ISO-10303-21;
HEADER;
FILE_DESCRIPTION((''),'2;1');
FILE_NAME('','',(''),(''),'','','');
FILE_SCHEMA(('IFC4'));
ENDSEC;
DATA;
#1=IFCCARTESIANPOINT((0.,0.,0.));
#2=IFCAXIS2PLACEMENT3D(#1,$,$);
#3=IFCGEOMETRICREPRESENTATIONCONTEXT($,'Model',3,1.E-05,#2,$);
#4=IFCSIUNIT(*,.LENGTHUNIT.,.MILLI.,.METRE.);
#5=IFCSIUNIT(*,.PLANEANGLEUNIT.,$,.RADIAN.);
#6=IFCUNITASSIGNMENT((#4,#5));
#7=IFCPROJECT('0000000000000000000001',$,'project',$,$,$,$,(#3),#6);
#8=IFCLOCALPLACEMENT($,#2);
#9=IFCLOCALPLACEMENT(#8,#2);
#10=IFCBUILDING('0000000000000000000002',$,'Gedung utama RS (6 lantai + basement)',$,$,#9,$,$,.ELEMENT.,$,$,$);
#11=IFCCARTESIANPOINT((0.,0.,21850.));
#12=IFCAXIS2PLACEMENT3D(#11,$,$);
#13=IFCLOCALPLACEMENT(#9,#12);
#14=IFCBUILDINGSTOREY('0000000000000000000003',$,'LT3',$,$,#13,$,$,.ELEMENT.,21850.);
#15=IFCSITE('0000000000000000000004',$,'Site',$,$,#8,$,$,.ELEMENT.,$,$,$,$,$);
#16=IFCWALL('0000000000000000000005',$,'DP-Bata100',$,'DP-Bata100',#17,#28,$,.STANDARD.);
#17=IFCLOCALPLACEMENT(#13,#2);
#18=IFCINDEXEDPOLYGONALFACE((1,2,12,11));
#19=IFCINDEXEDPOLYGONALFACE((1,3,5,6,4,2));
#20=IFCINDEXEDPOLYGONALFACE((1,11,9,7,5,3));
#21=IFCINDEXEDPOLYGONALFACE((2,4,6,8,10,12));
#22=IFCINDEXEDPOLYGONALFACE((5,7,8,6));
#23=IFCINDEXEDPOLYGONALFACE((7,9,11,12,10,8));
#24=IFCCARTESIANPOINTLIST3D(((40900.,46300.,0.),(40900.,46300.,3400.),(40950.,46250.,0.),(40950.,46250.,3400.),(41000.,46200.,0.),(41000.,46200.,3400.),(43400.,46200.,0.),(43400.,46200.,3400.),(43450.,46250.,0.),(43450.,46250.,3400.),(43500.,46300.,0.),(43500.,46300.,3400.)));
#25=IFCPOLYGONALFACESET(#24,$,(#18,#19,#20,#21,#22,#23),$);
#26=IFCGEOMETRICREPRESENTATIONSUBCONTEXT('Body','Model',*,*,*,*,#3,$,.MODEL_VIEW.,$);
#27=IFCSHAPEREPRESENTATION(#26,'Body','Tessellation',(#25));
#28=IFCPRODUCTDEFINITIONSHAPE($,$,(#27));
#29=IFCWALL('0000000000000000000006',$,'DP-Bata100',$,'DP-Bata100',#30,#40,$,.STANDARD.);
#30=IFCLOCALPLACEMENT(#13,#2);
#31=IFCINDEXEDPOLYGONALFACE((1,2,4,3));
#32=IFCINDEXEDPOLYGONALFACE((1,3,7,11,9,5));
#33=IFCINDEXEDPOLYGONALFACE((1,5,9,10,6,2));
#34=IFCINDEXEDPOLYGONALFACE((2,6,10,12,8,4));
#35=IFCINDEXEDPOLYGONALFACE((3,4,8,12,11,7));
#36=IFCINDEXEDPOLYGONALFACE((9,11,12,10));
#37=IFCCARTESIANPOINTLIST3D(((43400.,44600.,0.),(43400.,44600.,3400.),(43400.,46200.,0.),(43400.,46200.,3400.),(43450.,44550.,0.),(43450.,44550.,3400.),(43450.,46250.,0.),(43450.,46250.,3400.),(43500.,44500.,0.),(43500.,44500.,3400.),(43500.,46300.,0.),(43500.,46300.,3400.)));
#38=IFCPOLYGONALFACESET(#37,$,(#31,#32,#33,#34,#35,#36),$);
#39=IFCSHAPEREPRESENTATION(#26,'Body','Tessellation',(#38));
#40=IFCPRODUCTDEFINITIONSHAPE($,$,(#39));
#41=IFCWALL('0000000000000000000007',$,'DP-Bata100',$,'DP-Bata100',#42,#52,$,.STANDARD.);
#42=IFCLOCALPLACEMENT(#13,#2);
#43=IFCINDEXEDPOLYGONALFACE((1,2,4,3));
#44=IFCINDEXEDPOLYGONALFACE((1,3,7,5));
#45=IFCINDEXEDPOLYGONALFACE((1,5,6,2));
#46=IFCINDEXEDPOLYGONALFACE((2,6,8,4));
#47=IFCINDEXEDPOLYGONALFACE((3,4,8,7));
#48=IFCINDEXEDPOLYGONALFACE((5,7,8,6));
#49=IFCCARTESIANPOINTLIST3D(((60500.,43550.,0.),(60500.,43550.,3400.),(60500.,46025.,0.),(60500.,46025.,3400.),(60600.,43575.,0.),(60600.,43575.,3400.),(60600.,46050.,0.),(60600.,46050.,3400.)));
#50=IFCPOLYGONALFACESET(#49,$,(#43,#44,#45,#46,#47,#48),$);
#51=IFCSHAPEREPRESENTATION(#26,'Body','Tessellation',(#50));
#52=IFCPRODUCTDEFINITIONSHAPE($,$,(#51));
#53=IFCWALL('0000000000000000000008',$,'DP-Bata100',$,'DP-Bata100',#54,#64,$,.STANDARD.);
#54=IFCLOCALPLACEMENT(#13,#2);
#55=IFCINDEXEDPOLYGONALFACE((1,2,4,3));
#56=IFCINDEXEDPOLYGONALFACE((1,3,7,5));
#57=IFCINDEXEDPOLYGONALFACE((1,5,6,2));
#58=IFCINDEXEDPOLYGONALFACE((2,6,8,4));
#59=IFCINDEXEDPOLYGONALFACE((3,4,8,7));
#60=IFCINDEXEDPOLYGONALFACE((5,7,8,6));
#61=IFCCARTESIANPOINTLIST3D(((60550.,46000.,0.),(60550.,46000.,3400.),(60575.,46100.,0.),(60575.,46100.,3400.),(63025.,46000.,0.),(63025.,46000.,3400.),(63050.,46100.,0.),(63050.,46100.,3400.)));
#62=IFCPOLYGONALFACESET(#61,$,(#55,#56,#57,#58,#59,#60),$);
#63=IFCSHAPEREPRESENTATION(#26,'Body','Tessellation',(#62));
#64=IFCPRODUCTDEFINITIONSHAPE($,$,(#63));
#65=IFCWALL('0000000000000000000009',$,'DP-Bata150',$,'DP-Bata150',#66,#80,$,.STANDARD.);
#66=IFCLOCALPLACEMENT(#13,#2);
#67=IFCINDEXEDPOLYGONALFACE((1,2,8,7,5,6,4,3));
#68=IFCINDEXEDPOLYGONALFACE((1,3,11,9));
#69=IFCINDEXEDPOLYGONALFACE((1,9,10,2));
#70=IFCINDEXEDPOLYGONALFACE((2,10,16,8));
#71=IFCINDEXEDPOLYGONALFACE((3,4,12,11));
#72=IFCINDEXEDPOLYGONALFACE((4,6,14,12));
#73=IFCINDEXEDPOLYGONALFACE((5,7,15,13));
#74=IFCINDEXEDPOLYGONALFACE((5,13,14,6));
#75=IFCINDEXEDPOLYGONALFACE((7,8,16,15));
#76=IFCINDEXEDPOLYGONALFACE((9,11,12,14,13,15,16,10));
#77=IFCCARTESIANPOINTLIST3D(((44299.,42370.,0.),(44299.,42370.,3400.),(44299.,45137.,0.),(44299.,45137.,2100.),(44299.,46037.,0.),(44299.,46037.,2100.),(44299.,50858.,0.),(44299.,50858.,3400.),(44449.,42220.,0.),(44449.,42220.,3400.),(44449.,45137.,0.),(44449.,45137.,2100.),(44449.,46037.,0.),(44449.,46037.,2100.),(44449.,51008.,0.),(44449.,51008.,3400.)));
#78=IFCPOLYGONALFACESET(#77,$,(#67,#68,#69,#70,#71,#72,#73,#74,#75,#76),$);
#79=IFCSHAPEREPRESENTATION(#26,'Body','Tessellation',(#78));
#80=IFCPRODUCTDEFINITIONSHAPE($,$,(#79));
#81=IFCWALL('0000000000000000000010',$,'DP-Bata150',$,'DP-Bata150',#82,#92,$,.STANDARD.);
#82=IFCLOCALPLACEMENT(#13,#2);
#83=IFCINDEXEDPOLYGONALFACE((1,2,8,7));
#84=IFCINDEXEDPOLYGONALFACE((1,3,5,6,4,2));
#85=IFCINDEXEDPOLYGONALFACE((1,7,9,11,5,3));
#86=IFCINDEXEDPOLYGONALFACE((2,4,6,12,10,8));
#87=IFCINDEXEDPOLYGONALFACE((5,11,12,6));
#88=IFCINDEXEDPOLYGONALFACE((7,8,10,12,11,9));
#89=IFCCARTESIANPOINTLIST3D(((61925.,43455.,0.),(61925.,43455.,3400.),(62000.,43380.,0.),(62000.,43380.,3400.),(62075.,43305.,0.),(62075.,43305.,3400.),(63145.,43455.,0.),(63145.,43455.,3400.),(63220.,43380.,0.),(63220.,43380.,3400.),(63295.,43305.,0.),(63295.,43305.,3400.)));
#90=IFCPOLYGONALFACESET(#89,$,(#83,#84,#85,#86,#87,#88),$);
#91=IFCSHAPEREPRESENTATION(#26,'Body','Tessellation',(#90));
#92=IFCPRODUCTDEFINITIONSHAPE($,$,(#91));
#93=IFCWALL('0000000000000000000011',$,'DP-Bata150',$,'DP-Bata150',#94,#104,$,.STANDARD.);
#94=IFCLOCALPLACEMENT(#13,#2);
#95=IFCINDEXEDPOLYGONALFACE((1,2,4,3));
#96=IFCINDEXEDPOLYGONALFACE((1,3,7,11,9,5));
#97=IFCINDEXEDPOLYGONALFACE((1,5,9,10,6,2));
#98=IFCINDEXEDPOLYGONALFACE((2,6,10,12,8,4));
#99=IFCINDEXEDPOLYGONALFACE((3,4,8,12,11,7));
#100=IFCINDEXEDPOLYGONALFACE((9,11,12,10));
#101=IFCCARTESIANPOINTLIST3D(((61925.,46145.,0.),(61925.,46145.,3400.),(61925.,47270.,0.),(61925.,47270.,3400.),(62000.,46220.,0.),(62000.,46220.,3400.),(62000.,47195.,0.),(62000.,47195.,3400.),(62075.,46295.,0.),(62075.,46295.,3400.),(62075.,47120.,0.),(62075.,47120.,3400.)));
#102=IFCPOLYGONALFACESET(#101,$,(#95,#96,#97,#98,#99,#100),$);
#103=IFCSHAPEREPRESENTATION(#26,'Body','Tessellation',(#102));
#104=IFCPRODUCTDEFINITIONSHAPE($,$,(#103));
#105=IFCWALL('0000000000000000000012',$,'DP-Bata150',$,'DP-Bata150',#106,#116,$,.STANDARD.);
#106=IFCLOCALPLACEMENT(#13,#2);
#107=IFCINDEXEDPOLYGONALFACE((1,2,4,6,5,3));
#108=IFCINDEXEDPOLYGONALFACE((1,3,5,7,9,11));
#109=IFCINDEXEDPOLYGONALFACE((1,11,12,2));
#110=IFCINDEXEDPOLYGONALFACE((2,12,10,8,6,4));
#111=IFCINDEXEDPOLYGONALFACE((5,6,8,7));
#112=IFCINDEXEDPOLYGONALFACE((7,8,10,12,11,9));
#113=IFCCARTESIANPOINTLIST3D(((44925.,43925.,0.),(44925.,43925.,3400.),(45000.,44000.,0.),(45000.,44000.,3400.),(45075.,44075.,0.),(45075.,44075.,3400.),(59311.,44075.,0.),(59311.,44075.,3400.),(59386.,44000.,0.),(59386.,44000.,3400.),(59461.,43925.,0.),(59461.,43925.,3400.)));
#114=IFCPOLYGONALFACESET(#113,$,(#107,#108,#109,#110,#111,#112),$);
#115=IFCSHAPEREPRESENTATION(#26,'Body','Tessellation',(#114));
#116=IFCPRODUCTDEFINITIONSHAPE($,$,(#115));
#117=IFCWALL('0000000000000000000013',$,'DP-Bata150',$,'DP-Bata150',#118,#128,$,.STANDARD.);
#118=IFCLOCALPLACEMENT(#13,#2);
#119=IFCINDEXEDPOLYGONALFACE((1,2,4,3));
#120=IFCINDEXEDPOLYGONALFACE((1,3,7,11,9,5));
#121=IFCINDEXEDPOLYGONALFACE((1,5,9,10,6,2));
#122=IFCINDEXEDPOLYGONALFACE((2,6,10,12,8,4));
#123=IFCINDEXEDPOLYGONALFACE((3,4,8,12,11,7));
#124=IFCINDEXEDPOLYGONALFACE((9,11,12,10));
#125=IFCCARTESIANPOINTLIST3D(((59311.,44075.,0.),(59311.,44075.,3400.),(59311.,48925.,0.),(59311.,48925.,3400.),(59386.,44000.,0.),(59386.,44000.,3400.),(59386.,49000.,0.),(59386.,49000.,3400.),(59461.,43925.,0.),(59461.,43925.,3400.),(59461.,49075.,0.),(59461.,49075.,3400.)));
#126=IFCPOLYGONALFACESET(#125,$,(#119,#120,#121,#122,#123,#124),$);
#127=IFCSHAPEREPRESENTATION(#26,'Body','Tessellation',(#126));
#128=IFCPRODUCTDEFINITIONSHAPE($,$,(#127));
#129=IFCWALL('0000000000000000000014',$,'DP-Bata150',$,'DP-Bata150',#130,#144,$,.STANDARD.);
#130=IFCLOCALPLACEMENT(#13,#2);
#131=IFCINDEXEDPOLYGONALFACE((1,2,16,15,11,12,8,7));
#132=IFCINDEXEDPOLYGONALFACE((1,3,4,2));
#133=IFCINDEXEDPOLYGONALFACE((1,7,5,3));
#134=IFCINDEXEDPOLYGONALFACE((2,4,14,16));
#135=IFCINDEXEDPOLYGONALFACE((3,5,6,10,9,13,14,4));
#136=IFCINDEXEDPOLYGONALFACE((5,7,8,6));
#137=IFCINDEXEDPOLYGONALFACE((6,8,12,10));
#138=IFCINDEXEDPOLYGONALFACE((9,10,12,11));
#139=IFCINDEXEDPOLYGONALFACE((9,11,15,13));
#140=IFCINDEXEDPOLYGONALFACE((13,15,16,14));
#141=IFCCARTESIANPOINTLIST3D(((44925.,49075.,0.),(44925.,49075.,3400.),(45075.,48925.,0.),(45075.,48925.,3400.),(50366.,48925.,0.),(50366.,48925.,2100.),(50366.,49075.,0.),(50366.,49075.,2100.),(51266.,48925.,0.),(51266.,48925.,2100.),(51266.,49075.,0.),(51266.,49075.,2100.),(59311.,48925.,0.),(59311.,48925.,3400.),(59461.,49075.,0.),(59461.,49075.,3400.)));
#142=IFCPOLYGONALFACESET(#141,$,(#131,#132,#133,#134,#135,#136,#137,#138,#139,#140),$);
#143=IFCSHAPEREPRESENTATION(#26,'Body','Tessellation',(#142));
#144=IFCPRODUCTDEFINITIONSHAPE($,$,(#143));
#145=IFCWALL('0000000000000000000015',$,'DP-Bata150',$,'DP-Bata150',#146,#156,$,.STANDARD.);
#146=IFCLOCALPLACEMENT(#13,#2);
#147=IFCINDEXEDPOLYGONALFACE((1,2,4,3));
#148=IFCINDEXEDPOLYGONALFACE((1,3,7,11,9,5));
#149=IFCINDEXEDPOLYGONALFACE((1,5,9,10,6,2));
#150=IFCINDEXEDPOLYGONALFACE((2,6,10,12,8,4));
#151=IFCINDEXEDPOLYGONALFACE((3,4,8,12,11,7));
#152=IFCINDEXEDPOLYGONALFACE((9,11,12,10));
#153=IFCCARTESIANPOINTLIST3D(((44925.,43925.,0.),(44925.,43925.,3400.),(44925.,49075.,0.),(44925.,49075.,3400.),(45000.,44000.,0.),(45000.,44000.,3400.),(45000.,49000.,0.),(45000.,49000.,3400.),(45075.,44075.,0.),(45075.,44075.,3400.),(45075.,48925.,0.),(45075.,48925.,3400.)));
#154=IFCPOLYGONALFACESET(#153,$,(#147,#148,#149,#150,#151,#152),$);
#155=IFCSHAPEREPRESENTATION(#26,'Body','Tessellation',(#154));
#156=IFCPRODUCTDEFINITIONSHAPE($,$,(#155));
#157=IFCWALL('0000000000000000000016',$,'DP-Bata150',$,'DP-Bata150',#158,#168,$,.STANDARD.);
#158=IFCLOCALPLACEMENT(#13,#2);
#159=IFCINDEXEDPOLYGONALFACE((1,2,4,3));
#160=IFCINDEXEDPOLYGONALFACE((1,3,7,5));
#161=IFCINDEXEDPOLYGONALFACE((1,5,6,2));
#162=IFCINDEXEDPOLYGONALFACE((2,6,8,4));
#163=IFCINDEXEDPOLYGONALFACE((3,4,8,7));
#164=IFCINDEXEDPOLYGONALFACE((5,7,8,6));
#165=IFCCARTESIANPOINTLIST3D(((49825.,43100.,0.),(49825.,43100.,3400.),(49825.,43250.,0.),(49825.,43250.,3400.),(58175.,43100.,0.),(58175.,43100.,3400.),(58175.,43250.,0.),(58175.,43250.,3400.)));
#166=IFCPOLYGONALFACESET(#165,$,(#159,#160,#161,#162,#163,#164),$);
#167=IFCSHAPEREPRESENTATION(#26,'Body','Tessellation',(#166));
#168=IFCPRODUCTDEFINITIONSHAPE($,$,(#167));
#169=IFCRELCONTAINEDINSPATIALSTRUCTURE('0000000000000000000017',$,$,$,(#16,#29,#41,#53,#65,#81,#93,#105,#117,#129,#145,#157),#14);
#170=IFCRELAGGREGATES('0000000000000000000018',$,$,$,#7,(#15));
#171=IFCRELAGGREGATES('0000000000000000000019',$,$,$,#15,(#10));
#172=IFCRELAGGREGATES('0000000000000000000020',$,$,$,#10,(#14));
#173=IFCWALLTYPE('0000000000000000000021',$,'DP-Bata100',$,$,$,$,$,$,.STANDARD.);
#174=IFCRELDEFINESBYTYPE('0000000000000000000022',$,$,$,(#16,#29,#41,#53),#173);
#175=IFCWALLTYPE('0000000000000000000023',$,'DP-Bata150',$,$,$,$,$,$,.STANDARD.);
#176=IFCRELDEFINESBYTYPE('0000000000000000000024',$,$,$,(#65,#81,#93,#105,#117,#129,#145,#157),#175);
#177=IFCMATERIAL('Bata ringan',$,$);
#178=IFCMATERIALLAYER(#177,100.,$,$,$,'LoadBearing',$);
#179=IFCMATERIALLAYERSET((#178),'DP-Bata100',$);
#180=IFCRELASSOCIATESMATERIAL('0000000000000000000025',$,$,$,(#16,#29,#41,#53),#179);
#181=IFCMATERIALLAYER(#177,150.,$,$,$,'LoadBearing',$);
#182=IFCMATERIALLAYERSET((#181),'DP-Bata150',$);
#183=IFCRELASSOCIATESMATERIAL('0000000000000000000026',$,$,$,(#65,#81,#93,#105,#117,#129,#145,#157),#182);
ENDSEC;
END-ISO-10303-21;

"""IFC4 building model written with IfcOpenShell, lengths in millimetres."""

from ifc_helpers import new_model, si_unit, frame, frame_2d, origin, place, context, subcontext, project, spatial, polyline, rectangle, outline, extrude, material, layer, layer_set, layer_usage, type_object, element, save


model = new_model("IFC4")

# Units and contexts
model_context = context("Model", 3, precision=1e-05, world=origin())
body_context = subcontext(model_context, "Body", "Model", "MODEL_VIEW")
ifc_project = project(units=[si_unit("LENGTHUNIT", "METRE", prefix="MILLI"), si_unit("PLANEANGLEUNIT", "RADIAN")], contexts=[model_context])

# Site, building, storey
site_placement = place(None, origin())
site = spatial("IfcSite", under=ifc_project, at=site_placement, Name="Site", CompositionType="ELEMENT")
building_placement = place(site_placement, origin())
building = spatial("IfcBuilding", under=site, at=building_placement, Name="Gedung utama RS (6 lantai + basement)", CompositionType="ELEMENT")
storey_placement = place(building_placement, frame((0.0, 0.0, 21850.0)))
storey = spatial("IfcBuildingStorey", under=building, at=storey_placement, Name="LT3", CompositionType="ELEMENT", Elevation=21850.0)

# Walls
ifc_material_1 = material(Name="Bata ringan")
ifc_layer_1 = layer(ifc_material_1, 100.0, Category="LoadBearing")
ifc_layer_set_1 = layer_set([ifc_layer_1], Name="DP-Bata100")
ifc_layer_usage_1 = layer_usage(ifc_layer_set_1, "AXIS2", "NEGATIVE", 50.0)
wall_type_1 = type_object("IfcWallType", Name="DP-Bata100", PredefinedType="STANDARD")
for number, where, z_axis, x_axis, name in (
    (1, (40950.0, 46250.0, 0.0), (0.0, 0.0, 1.0), (1.0, 0.0, 0.0), "DP-Bata100"),
):
    element("IfcWall", number, at=place(storey_placement, frame(where, z_axis=z_axis, x_axis=x_axis)), inside=storey, type_object=wall_type_1, material=ifc_layer_usage_1, Name=name, ObjectType="DP-Bata100", PredefinedType="STANDARD", context=body_context, shape_type="SweptSolid", body=[
        extrude(outline(polyline([(50.0, -50.0), (0.0, 0.0), (-50.0, 50.0), (2550.0, 50.0), (2500.0, 0.0), (2450.0, -50.0), (50.0, -50.0)])), origin(), (0.0, 0.0, 1.0), 3400.0),
    ])
wall_1_placement = place(storey_placement, frame((43450.0, 46250.0, 0.0), z_axis=(0.0, 0.0, 1.0), x_axis=(0.0, -1.0, 0.0)))
element("IfcWall", 2, at=wall_1_placement, inside=storey, type_object=wall_type_1, material=ifc_layer_usage_1, Name="DP-Bata100", ObjectType="DP-Bata100", PredefinedType="STANDARD", context=body_context, shape_type="SweptSolid", body=[
    extrude(outline(polyline([(50.0, -50.0), (0.0, 0.0), (-50.0, 50.0), (1750.0, 50.0), (1700.0, 0.0), (1650.0, -50.0), (50.0, -50.0)])), origin(), (0.0, 0.0, 1.0), 3400.0),
])
wall_2_placement = place(storey_placement, frame((60550.0, 43550.0, 0.0), z_axis=(0.0, 0.0, 1.0), x_axis=(0.0, 1.0, 0.0)))
element("IfcWall", 3, at=wall_2_placement, inside=storey, type_object=wall_type_1, material=ifc_layer_usage_1, Name="DP-Bata100", ObjectType="DP-Bata100", PredefinedType="STANDARD", context=body_context, shape_type="SweptSolid", body=[
    extrude(outline(polyline([(25.0, -50.0), (0.0, 50.0), (2475.0, 50.0), (2500.0, -50.0), (25.0, -50.0)])), origin(), (0.0, 0.0, 1.0), 3400.0),
])
wall_3_placement = place(storey_placement, frame((60550.0, 46050.0, 0.0), z_axis=(0.0, 0.0, 1.0), x_axis=(1.0, 0.0, 0.0)))
element("IfcWall", 4, at=wall_3_placement, inside=storey, type_object=wall_type_1, material=ifc_layer_usage_1, Name="DP-Bata100", ObjectType="DP-Bata100", PredefinedType="STANDARD", context=body_context, shape_type="SweptSolid", body=[
    extrude(outline(polyline([(0.0, -50.0), (25.0, 50.0), (2500.0, 50.0), (2475.0, -50.0), (0.0, -50.0)])), origin(), (0.0, 0.0, 1.0), 3400.0),
])

# Wall, opening
ifc_layer_2 = layer(ifc_material_1, 150.0, Category="LoadBearing")
ifc_layer_set_2 = layer_set([ifc_layer_2], Name="DP-Bata150")
ifc_layer_usage_2 = layer_usage(ifc_layer_set_2, "AXIS2", "NEGATIVE", 75.0)
wall_type_2 = type_object("IfcWallType", Name="DP-Bata150", PredefinedType="STANDARD")
wall_4_placement = place(storey_placement, frame((44374.0, 50933.0, 0.0), z_axis=(0.0, 0.0, 1.0), x_axis=(0.0, -1.0, 0.0)))
wall_4 = element("IfcWall", 5, at=wall_4_placement, inside=storey, type_object=wall_type_2, material=ifc_layer_usage_2, Name="DP-Bata150", ObjectType="DP-Bata150", PredefinedType="STANDARD", context=body_context, shape_type="SweptSolid", body=[
    extrude(outline(polyline([(75.0, -75.0), (0.0, 0.0), (-75.0, 75.0), (8713.0, 75.0), (8638.0, 0.0), (8563.0, -75.0), (75.0, -75.0)])), origin(), (0.0, 0.0, 1.0), 3400.0),
])
opening_1_placement = place(wall_4_placement, frame((4896.0, 0.0, 0.0), z_axis=(0.0, 0.0, 1.0), x_axis=(1.0, 0.0, 0.0)))
element("IfcOpeningElement", 6, at=opening_1_placement, cuts=wall_4, PredefinedType="OPENING", context=body_context, shape_type="SweptSolid", body=[
    extrude(rectangle(XDim=900.0, YDim=170.0, at=frame_2d((450.0, 0.0))), origin(), (0.0, 0.0, 1.0), 2100.0),
])

# Walls
wall_5_placement = place(storey_placement, frame((62000.0, 43380.0, 0.0), z_axis=(0.0, 0.0, 1.0), x_axis=(1.0, 0.0, 0.0)))
element("IfcWall", 7, at=wall_5_placement, inside=storey, type_object=wall_type_2, material=ifc_layer_usage_2, Name="DP-Bata150", ObjectType="DP-Bata150", PredefinedType="STANDARD", context=body_context, shape_type="SweptSolid", body=[
    extrude(outline(polyline([(75.0, -75.0), (0.0, 0.0), (-75.0, 75.0), (1145.0, 75.0), (1220.0, 0.0), (1295.0, -75.0), (75.0, -75.0)])), origin(), (0.0, 0.0, 1.0), 3400.0),
])
wall_6_placement = place(storey_placement, frame((62000.0, 46220.0, 0.0), z_axis=(0.0, 0.0, 1.0), x_axis=(0.0, 1.0, 0.0)))
element("IfcWall", 8, at=wall_6_placement, inside=storey, type_object=wall_type_2, material=ifc_layer_usage_2, Name="DP-Bata150", ObjectType="DP-Bata150", PredefinedType="STANDARD", context=body_context, shape_type="SweptSolid", body=[
    extrude(outline(polyline([(75.0, -75.0), (0.0, 0.0), (-75.0, 75.0), (1050.0, 75.0), (975.0, 0.0), (900.0, -75.0), (75.0, -75.0)])), origin(), (0.0, 0.0, 1.0), 3400.0),
])
wall_7_placement = place(storey_placement, frame((45000.0, 44000.0, 0.0), z_axis=(0.0, 0.0, 1.0), x_axis=(1.0, 0.0, 0.0)))
element("IfcWall", 9, at=wall_7_placement, inside=storey, type_object=wall_type_2, material=ifc_layer_usage_2, Name="DP-Bata150", ObjectType="DP-Bata150", PredefinedType="STANDARD", context=body_context, shape_type="SweptSolid", body=[
    extrude(outline(polyline([(-75.0, -75.0), (0.0, 0.0), (75.0, 75.0), (14311.0, 75.0), (14386.0, 0.0), (14461.0, -75.0), (-75.0, -75.0)])), origin(), (0.0, 0.0, 1.0), 3400.0),
])
wall_8_placement = place(storey_placement, frame((59386.0, 44000.0, 0.0), z_axis=(0.0, 0.0, 1.0), x_axis=(0.0, 1.0, 0.0)))
element("IfcWall", 10, at=wall_8_placement, inside=storey, type_object=wall_type_2, material=ifc_layer_usage_2, Name="DP-Bata150", ObjectType="DP-Bata150", PredefinedType="STANDARD", context=body_context, shape_type="SweptSolid", body=[
    extrude(outline(polyline([(-75.0, -75.0), (0.0, 0.0), (75.0, 75.0), (4925.0, 75.0), (5000.0, 0.0), (5075.0, -75.0), (-75.0, -75.0)])), origin(), (0.0, 0.0, 1.0), 3400.0),
])

# Wall, opening
wall_9_placement = place(storey_placement, frame((59386.0, 49000.0, 0.0), z_axis=(0.0, 0.0, 1.0), x_axis=(-1.0, 0.0, 0.0)))
wall_9 = element("IfcWall", 11, at=wall_9_placement, inside=storey, type_object=wall_type_2, material=ifc_layer_usage_2, Name="DP-Bata150", ObjectType="DP-Bata150", PredefinedType="STANDARD", context=body_context, shape_type="SweptSolid", body=[
    extrude(outline(polyline([(-75.0, -75.0), (0.0, 0.0), (75.0, 75.0), (14311.0, 75.0), (14386.0, 0.0), (14461.0, -75.0), (-75.0, -75.0)])), origin(), (0.0, 0.0, 1.0), 3400.0),
])
opening_2_placement = place(wall_9_placement, frame((8120.0, 0.0, 0.0), z_axis=(0.0, 0.0, 1.0), x_axis=(1.0, 0.0, 0.0)))
element("IfcOpeningElement", 12, at=opening_2_placement, cuts=wall_9, PredefinedType="OPENING", context=body_context, shape_type="SweptSolid", body=[
    extrude(rectangle(XDim=900.0, YDim=170.0, at=frame_2d((450.0, 0.0))), origin(), (0.0, 0.0, 1.0), 2100.0),
])

# Walls
wall_10_placement = place(storey_placement, frame((45000.0, 49000.0, 0.0), z_axis=(0.0, 0.0, 1.0), x_axis=(0.0, -1.0, 0.0)))
element("IfcWall", 13, at=wall_10_placement, inside=storey, type_object=wall_type_2, material=ifc_layer_usage_2, Name="DP-Bata150", ObjectType="DP-Bata150", PredefinedType="STANDARD", context=body_context, shape_type="SweptSolid", body=[
    extrude(outline(polyline([(-75.0, -75.0), (0.0, 0.0), (75.0, 75.0), (4925.0, 75.0), (5000.0, 0.0), (5075.0, -75.0), (-75.0, -75.0)])), origin(), (0.0, 0.0, 1.0), 3400.0),
])
for number, where, z_axis, x_axis, name in (
    (14, (58175.0, 43175.0, 0.0), (0.0, 0.0, 1.0), (-1.0, 0.0, 0.0), "DP-Bata150"),
):
    element("IfcWall", number, at=place(storey_placement, frame(where, z_axis=z_axis, x_axis=x_axis)), inside=storey, type_object=wall_type_2, material=ifc_layer_usage_2, Name=name, ObjectType="DP-Bata150", PredefinedType="STANDARD", context=body_context, shape_type="SweptSolid", body=[
        extrude(outline(polyline([(0.0, -75.0), (0.0, 75.0), (8350.0, 75.0), (8350.0, -75.0), (0.0, -75.0)])), origin(), (0.0, 0.0, 1.0), 3400.0),
    ])

save(model, "model.ifc")
